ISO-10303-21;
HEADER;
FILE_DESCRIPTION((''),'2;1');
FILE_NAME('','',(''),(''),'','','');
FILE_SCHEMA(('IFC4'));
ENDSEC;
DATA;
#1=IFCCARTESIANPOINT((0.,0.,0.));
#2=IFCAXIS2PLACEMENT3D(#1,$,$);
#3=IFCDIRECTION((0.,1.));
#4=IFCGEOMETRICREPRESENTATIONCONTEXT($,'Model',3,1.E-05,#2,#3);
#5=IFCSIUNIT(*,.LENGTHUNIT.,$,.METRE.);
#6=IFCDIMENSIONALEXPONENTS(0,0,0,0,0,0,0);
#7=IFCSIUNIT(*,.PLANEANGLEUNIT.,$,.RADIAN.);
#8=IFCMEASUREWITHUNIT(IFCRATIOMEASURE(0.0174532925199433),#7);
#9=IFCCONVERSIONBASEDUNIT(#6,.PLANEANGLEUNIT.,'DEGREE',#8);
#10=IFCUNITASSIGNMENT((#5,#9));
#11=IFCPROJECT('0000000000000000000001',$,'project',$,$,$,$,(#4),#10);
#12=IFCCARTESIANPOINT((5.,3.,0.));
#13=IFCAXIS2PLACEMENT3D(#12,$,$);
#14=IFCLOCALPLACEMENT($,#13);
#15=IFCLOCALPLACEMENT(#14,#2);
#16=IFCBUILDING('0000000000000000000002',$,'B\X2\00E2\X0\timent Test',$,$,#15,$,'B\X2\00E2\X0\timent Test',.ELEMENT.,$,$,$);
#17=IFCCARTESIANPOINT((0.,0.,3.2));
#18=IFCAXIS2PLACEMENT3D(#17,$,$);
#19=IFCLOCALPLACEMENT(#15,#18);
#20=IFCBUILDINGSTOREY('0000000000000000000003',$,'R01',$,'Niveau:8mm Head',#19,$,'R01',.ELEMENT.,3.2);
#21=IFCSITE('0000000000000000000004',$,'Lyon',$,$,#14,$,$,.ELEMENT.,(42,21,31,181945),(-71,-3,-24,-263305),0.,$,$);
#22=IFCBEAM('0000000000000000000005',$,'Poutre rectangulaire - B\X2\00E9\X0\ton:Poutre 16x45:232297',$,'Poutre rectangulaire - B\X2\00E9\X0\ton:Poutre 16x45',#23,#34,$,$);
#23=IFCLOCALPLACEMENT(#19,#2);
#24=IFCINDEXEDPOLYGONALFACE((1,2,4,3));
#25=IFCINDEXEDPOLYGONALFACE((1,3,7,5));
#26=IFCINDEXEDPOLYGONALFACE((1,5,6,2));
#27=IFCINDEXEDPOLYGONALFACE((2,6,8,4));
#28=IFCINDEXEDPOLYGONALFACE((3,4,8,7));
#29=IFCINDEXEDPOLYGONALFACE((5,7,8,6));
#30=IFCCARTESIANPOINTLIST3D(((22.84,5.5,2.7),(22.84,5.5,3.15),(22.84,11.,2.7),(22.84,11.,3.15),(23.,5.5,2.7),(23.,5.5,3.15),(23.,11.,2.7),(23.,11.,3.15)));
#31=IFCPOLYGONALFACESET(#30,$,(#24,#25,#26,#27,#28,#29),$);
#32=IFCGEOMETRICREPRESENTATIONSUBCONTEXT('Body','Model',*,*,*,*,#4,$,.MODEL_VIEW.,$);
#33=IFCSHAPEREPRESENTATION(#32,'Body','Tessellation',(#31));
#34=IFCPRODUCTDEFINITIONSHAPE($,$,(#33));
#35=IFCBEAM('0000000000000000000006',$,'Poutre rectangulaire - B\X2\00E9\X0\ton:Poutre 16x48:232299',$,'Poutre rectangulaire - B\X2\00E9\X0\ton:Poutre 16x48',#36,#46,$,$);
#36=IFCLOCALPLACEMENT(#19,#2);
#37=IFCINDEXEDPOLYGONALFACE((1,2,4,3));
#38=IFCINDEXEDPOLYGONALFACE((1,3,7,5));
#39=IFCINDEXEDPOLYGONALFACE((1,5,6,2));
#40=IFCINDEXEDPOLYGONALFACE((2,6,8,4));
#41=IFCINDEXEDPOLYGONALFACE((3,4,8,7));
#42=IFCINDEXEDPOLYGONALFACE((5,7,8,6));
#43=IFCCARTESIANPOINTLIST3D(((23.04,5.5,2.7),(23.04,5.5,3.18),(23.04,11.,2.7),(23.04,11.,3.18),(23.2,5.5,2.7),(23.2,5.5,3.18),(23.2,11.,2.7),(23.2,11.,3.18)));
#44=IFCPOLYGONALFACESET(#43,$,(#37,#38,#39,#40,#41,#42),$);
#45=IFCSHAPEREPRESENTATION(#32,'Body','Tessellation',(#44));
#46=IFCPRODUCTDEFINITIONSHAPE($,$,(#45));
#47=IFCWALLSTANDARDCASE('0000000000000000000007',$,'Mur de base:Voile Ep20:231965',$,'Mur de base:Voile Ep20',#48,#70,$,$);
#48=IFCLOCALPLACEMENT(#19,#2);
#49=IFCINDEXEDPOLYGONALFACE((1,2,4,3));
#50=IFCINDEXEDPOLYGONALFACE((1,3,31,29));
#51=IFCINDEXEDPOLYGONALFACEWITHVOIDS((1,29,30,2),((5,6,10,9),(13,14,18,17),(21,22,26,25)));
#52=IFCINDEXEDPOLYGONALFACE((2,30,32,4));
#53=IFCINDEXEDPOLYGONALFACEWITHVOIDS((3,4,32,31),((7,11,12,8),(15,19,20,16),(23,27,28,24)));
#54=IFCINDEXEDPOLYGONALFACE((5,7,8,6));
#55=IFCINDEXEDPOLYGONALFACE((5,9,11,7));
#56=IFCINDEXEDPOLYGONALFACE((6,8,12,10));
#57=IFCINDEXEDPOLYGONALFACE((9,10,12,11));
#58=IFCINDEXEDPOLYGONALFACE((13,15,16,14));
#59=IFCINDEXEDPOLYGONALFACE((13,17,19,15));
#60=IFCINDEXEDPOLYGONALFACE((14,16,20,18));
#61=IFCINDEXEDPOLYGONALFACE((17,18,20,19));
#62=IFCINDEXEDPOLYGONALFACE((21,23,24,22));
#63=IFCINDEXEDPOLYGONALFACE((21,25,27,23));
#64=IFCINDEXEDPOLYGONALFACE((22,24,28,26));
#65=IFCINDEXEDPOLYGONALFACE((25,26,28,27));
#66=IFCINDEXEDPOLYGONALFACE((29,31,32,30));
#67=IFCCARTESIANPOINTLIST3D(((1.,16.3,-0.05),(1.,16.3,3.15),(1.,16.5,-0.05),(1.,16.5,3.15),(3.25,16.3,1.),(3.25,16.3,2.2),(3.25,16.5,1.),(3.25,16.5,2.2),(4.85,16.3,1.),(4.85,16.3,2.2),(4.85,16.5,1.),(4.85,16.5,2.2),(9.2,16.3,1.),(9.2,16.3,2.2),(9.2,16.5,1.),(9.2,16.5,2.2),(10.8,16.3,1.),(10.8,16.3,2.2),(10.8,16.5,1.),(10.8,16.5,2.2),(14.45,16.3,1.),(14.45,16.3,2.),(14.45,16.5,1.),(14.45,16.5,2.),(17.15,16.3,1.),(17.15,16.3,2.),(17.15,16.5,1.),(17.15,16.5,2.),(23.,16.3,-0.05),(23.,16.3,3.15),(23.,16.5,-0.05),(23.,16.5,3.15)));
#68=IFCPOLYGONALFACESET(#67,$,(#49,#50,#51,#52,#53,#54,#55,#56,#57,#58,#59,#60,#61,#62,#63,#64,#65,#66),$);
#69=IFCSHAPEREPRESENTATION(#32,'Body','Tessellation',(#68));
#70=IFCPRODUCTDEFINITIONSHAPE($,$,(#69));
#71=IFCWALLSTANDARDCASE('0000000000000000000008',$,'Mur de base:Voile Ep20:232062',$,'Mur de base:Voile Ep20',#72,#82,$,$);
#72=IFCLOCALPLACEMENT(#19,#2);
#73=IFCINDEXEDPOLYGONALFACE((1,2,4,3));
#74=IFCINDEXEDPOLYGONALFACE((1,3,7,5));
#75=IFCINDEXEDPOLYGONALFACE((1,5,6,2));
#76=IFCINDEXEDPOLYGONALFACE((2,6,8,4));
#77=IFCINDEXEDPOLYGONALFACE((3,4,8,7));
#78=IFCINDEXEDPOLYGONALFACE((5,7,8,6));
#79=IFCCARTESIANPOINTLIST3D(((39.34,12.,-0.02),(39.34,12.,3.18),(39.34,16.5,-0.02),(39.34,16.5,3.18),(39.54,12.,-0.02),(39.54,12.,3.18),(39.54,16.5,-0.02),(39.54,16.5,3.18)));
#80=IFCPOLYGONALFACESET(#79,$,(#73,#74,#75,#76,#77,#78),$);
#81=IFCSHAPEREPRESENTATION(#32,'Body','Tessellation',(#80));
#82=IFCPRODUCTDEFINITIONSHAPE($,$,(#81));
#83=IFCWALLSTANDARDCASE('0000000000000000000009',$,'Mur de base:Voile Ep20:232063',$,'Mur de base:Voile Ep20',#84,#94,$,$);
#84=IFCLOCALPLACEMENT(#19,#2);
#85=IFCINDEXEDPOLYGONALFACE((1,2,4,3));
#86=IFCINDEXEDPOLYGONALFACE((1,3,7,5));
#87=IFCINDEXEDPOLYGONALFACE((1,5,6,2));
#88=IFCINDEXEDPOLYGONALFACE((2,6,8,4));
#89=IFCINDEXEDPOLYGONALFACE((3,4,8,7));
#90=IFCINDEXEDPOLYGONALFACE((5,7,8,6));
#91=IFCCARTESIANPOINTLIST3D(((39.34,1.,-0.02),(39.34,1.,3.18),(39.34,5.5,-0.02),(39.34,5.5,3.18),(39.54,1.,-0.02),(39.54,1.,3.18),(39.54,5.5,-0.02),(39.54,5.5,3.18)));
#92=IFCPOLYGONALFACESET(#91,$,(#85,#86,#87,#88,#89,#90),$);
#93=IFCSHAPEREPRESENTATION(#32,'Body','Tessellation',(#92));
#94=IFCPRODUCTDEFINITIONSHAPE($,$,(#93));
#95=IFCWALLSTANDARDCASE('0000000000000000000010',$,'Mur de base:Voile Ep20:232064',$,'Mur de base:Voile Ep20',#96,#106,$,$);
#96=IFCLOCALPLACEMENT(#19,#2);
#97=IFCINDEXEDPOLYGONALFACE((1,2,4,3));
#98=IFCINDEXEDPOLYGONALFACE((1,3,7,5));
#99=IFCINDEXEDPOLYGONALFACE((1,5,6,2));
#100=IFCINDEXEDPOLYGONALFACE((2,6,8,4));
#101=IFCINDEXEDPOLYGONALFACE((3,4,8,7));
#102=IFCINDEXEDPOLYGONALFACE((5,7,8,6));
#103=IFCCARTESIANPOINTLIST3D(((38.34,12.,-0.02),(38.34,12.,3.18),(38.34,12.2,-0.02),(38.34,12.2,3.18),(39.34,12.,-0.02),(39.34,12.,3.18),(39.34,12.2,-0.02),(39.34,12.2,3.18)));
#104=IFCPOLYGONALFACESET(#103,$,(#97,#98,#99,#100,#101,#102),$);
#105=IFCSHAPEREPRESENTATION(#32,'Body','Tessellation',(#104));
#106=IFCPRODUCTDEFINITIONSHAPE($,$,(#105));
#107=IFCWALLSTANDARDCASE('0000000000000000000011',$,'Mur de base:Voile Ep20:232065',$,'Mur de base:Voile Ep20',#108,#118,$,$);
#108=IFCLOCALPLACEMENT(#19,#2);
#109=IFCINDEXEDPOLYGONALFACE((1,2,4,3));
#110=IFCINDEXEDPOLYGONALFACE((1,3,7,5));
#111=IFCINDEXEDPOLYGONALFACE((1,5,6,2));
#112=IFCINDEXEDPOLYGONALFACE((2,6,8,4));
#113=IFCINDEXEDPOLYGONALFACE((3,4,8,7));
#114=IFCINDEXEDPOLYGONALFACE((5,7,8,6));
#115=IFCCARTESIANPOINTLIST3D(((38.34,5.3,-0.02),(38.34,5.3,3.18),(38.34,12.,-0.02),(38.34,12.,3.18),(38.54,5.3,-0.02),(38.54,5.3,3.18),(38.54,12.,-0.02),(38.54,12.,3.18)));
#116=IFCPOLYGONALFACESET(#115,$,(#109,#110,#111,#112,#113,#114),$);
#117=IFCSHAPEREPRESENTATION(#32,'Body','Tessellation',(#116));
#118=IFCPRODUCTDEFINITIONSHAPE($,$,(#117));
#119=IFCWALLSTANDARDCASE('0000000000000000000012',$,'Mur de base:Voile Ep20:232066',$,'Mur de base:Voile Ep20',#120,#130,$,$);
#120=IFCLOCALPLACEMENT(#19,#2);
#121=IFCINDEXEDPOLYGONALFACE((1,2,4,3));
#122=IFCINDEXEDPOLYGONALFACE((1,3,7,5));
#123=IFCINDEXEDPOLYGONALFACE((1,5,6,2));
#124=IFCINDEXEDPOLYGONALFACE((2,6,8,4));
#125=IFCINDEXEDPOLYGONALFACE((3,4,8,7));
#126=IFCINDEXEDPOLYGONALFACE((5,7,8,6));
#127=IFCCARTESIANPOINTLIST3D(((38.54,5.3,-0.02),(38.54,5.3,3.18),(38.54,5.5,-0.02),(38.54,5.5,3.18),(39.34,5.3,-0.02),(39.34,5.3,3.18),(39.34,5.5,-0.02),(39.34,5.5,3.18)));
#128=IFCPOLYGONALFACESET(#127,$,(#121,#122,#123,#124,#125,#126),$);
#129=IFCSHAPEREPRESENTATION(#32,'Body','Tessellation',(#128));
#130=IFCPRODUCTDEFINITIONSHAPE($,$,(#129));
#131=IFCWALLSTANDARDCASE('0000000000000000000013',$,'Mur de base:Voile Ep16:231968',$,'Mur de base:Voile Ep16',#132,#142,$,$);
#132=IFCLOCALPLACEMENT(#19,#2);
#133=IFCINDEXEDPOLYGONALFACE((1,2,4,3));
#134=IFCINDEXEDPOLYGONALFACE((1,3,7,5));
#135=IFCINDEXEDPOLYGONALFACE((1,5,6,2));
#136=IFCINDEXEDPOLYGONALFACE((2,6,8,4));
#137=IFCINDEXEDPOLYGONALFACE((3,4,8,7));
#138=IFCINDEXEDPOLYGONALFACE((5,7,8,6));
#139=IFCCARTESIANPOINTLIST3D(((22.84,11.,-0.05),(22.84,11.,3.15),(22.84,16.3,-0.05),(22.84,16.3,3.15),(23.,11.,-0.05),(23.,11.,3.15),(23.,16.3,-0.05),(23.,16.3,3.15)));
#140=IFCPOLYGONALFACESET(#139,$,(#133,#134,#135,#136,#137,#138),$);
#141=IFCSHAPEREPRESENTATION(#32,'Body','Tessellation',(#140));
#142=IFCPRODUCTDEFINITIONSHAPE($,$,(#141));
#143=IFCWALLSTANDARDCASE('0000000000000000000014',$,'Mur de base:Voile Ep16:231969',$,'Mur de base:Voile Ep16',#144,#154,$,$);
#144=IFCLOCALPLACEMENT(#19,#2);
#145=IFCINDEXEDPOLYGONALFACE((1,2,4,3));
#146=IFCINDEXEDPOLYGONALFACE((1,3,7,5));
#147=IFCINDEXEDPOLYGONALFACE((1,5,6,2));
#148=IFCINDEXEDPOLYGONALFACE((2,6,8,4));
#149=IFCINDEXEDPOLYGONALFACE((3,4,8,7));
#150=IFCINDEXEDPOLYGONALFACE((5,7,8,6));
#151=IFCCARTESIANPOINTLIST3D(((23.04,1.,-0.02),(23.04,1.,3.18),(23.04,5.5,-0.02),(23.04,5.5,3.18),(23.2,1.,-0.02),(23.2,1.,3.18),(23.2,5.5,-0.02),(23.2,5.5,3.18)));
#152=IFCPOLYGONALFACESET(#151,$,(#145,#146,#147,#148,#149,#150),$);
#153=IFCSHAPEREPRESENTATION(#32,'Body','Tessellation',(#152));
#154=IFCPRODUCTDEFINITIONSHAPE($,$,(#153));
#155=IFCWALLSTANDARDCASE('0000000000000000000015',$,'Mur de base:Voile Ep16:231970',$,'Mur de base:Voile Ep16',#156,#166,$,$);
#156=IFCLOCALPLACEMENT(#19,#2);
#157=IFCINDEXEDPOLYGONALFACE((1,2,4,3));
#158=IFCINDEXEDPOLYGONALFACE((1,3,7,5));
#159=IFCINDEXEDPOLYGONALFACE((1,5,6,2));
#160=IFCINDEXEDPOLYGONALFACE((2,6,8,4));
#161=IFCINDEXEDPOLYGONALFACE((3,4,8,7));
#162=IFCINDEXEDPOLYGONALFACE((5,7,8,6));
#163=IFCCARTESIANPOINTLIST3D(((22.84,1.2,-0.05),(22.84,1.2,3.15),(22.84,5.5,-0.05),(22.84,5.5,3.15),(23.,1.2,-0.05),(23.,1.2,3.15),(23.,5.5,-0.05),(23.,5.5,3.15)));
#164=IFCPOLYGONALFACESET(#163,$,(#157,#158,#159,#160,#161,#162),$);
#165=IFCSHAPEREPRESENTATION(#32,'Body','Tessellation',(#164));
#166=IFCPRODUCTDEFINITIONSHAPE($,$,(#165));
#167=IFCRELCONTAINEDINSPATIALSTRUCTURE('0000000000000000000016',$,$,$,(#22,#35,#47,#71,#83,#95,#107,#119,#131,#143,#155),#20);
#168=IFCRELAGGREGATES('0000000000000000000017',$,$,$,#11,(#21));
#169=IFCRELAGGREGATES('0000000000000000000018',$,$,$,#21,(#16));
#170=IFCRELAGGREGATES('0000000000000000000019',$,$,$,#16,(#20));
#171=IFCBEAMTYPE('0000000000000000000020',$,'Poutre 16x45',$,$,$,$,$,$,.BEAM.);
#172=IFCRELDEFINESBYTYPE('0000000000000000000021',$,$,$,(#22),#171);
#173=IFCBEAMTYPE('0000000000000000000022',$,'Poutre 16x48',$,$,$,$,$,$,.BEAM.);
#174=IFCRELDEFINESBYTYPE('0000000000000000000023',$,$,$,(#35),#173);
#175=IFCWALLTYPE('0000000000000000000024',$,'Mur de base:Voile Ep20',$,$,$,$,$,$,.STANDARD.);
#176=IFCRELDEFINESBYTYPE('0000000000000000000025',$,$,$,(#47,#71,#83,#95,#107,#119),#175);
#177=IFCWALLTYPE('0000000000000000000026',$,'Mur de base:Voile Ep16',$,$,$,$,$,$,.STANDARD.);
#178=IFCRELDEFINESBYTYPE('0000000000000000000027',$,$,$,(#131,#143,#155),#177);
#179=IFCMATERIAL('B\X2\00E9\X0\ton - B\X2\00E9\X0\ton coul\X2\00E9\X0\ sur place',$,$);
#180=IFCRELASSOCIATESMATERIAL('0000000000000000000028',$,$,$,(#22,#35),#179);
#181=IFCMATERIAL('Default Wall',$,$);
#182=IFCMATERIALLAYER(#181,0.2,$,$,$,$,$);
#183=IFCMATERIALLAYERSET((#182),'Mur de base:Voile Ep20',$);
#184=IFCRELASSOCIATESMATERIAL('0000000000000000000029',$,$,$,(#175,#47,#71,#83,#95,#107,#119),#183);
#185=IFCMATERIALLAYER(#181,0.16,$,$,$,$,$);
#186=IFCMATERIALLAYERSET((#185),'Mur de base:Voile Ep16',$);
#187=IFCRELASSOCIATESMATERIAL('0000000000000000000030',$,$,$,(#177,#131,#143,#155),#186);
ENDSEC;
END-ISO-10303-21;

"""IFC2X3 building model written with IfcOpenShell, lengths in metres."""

from ifc_helpers import new_model, entity, si_unit, converted_unit, direction, frame, frame_2d, origin, origin_2d_with_axis, place, context, subcontext, project, spatial, rectangle, extrude, material, layer, layer_set, layer_usage, type_object, element, save


model = new_model("IFC2X3")

# Units and contexts
model_context = context("Model", 3, precision=1e-05, world=origin(), true_north=direction((0.0, 1.0)))
body_context = subcontext(model_context, "Body", "Model", "MODEL_VIEW")
ifc_project = project(units=[si_unit("LENGTHUNIT", "METRE"), converted_unit("PLANEANGLEUNIT", "DEGREE", entity("IfcRatioMeasure", 0.0174532925199433), si_unit("PLANEANGLEUNIT", "RADIAN"), dimensions=[0, 0, 0, 0, 0, 0, 0])], contexts=[model_context])

# Site, building, storey
site_placement = place(None, frame((5.0, 3.0, 0.0)))
site = spatial("IfcSite", under=ifc_project, at=site_placement, Name="Lyon", CompositionType="ELEMENT", RefLatitude=(42, 21, 31, 181945), RefLongitude=(-71, -3, -24, -263305), RefElevation=0.0)
building_placement = place(site_placement, origin())
building = spatial("IfcBuilding", under=site, at=building_placement, Name="Bâtiment Test", LongName="Bâtiment Test", CompositionType="ELEMENT")
storey_placement = place(building_placement, frame((0.0, 0.0, 3.2)))
storey = spatial("IfcBuildingStorey", under=building, at=storey_placement, Name="R01", ObjectType="Niveau:8mm Head", LongName="R01", CompositionType="ELEMENT", Elevation=3.2)

# Beams
ifc_material_1 = material(Name="Béton - Béton coulé sur place")
beam_type_1 = type_object("IfcBeamType", Name="Poutre 16x45", PredefinedType="BEAM")
beam_1_placement = place(storey_placement, frame((22.92, 5.5, 3.15), z_axis=(0.0, 0.0, 1.0), x_axis=(0.0, 1.0, 0.0)))
element("IfcBeam", 1, at=beam_1_placement, inside=storey, type_object=beam_type_1, material=ifc_material_1, Name="Poutre rectangulaire - Béton:Poutre 16x45:232297", ObjectType="Poutre rectangulaire - Béton:Poutre 16x45", context=body_context, shape_type="SweptSolid", body=[
    extrude(rectangle(XDim=0.45, YDim=0.16, at=frame_2d((0.0, 0.0), x_axis=(1.0, 0.0))), frame((0.0, 0.0, -0.225), z_axis=(1.0, 0.0, 0.0), x_axis=(0.0, 0.0, -1.0)), (0.0, 0.0, 1.0), 5.5),
])
beam_type_2 = type_object("IfcBeamType", Name="Poutre 16x48", PredefinedType="BEAM")
beam_2_placement = place(storey_placement, frame((23.12, 11.0, 3.18), z_axis=(0.0, 0.0, 1.0), x_axis=(0.0, -1.0, 0.0)))
element("IfcBeam", 2, at=beam_2_placement, inside=storey, type_object=beam_type_2, material=ifc_material_1, Name="Poutre rectangulaire - Béton:Poutre 16x48:232299", ObjectType="Poutre rectangulaire - Béton:Poutre 16x48", context=body_context, shape_type="SweptSolid", body=[
    extrude(rectangle(XDim=0.48, YDim=0.16, at=frame_2d((0.0, 0.0), x_axis=(1.0, 0.0))), frame((0.0, 0.0, -0.24), z_axis=(1.0, 0.0, 0.0), x_axis=(0.0, 0.0, -1.0)), (0.0, 0.0, 1.0), 5.5),
])

# Wall, openings
ifc_material_2 = material(Name="Default Wall")
ifc_layer_1 = layer(ifc_material_2, 0.2)
ifc_layer_set_1 = layer_set([ifc_layer_1], Name="Mur de base:Voile Ep20")
ifc_layer_usage_1 = layer_usage(ifc_layer_set_1, "AXIS2", "POSITIVE", -0.1)
wall_type_1 = type_object("IfcWallType", Name="Mur de base:Voile Ep20", PredefinedType="STANDARD", material=ifc_layer_set_1)
wall_1_placement = place(storey_placement, frame((23.0, 16.4, -0.05), z_axis=(0.0, 0.0, 1.0), x_axis=(-1.0, 0.0, 0.0)))
wall_1 = element("IfcWallStandardCase", 3, at=wall_1_placement, inside=storey, type_object=wall_type_1, material=ifc_layer_usage_1, Name="Mur de base:Voile Ep20:231965", ObjectType="Mur de base:Voile Ep20", context=body_context, shape_type="SweptSolid", body=[
    extrude(rectangle(XDim=22.0, YDim=0.2, at=frame_2d((11.0, 0.0), x_axis=(-1.0, 0.0))), origin(), (0.0, 0.0, 1.0), 3.2),
])
opening_1_placement = place(wall_1_placement, origin())
element("IfcOpeningElement", 4, at=opening_1_placement, cuts=wall_1, ObjectType="Opening", context=body_context, shape_type="SweptSolid", body=[
    extrude(rectangle(XDim=1.0, YDim=2.7, at=frame_2d((0.0, 0.0), x_axis=(1.0, 0.0))), frame((7.2, -0.1, 1.55), z_axis=(0.0, 1.0, 0.0), x_axis=(0.0, 0.0, -1.0)), (0.0, 0.0, 1.0), 0.2),
])
opening_2_placement = place(wall_1_placement, origin())
element("IfcOpeningElement", 5, at=opening_2_placement, cuts=wall_1, ObjectType="Opening", context=body_context, shape_type="SweptSolid", body=[
    extrude(rectangle(XDim=1.2, YDim=1.6, at=origin_2d_with_axis()), frame((13.0, -0.1, 1.65), z_axis=(0.0, 1.0, 0.0), x_axis=(0.0, 0.0, -1.0)), (0.0, 0.0, 1.0), 0.2),
])
opening_3_placement = place(wall_1_placement, origin())
element("IfcOpeningElement", 6, at=opening_3_placement, cuts=wall_1, ObjectType="Opening", context=body_context, shape_type="SweptSolid", body=[
    extrude(rectangle(XDim=1.2, YDim=1.6, at=frame_2d((0.0, 0.0), x_axis=(1.0, 0.0))), frame((18.95, -0.1, 1.65), z_axis=(0.0, 1.0, 0.0), x_axis=(0.0, 0.0, -1.0)), (0.0, 0.0, 1.0), 0.2),
])

# Walls
ifc_layer_usage_2 = layer_usage(ifc_layer_set_1, "AXIS2", "NEGATIVE", 0.1)
wall_2_placement = place(storey_placement, frame((39.44, 16.5, -0.02), z_axis=(0.0, 0.0, 1.0), x_axis=(0.0, -1.0, 0.0)))
element("IfcWallStandardCase", 7, at=wall_2_placement, inside=storey, type_object=wall_type_1, material=ifc_layer_usage_2, Name="Mur de base:Voile Ep20:232062", ObjectType="Mur de base:Voile Ep20", context=body_context, shape_type="SweptSolid", body=[
    extrude(rectangle(XDim=4.5, YDim=0.2, at=frame_2d((2.25, 0.0), x_axis=(-1.0, 0.0))), origin(), (0.0, 0.0, 1.0), 3.2),
])
ifc_layer_usage_3 = layer_usage(ifc_layer_set_1, "AXIS2", "NEGATIVE", 0.1)
wall_3_placement = place(storey_placement, frame((39.44, 5.5, -0.02), z_axis=(0.0, 0.0, 1.0), x_axis=(0.0, -1.0, 0.0)))
element("IfcWallStandardCase", 8, at=wall_3_placement, inside=storey, type_object=wall_type_1, material=ifc_layer_usage_3, Name="Mur de base:Voile Ep20:232063", ObjectType="Mur de base:Voile Ep20", context=body_context, shape_type="SweptSolid", body=[
    extrude(rectangle(XDim=4.5, YDim=0.2, at=frame_2d((2.25, 0.0), x_axis=(-1.0, 0.0))), origin(), (0.0, 0.0, 1.0), 3.2),
])
ifc_layer_usage_4 = layer_usage(ifc_layer_set_1, "AXIS2", "NEGATIVE", 0.1)
wall_4_placement = place(storey_placement, frame((39.34, 12.1, -0.02), z_axis=(0.0, 0.0, 1.0), x_axis=(-1.0, 0.0, 0.0)))
element("IfcWallStandardCase", 9, at=wall_4_placement, inside=storey, type_object=wall_type_1, material=ifc_layer_usage_4, Name="Mur de base:Voile Ep20:232064", ObjectType="Mur de base:Voile Ep20", context=body_context, shape_type="SweptSolid", body=[
    extrude(rectangle(XDim=1.0, YDim=0.2, at=frame_2d((0.5, 0.0), x_axis=(-1.0, 0.0))), origin(), (0.0, 0.0, 1.0), 3.2),
])
ifc_layer_usage_5 = layer_usage(ifc_layer_set_1, "AXIS2", "NEGATIVE", 0.1)
wall_5_placement = place(storey_placement, frame((38.44, 12.0, -0.02), z_axis=(0.0, 0.0, 1.0), x_axis=(0.0, -1.0, 0.0)))
element("IfcWallStandardCase", 10, at=wall_5_placement, inside=storey, type_object=wall_type_1, material=ifc_layer_usage_5, Name="Mur de base:Voile Ep20:232065", ObjectType="Mur de base:Voile Ep20", context=body_context, shape_type="SweptSolid", body=[
    extrude(rectangle(XDim=6.7, YDim=0.2, at=frame_2d((3.35, 0.0), x_axis=(-1.0, 0.0))), origin(), (0.0, 0.0, 1.0), 3.2),
])
ifc_layer_usage_6 = layer_usage(ifc_layer_set_1, "AXIS2", "NEGATIVE", 0.1)
wall_6_placement = place(storey_placement, frame((38.54, 5.4, -0.02)))
element("IfcWallStandardCase", 11, at=wall_6_placement, inside=storey, type_object=wall_type_1, material=ifc_layer_usage_6, Name="Mur de base:Voile Ep20:232066", ObjectType="Mur de base:Voile Ep20", context=body_context, shape_type="SweptSolid", body=[
    extrude(rectangle(XDim=0.8, YDim=0.2, at=frame_2d((0.4, 0.0), x_axis=(-1.0, 0.0))), origin(), (0.0, 0.0, 1.0), 3.2),
])
ifc_layer_2 = layer(ifc_material_2, 0.16)
ifc_layer_set_2 = layer_set([ifc_layer_2], Name="Mur de base:Voile Ep16")
ifc_layer_usage_7 = layer_usage(ifc_layer_set_2, "AXIS2", "NEGATIVE", 0.08)
wall_type_2 = type_object("IfcWallType", Name="Mur de base:Voile Ep16", PredefinedType="STANDARD", material=ifc_layer_set_2)
wall_7_placement = place(storey_placement, frame((22.92, 16.3, -0.05), z_axis=(0.0, 0.0, 1.0), x_axis=(0.0, -1.0, 0.0)))
element("IfcWallStandardCase", 12, at=wall_7_placement, inside=storey, type_object=wall_type_2, material=ifc_layer_usage_7, Name="Mur de base:Voile Ep16:231968", ObjectType="Mur de base:Voile Ep16", context=body_context, shape_type="SweptSolid", body=[
    extrude(rectangle(XDim=5.3, YDim=0.16, at=frame_2d((2.65, 0.0), x_axis=(-1.0, 0.0))), origin(), (0.0, 0.0, 1.0), 3.2),
])
ifc_layer_usage_8 = layer_usage(ifc_layer_set_2, "AXIS2", "NEGATIVE", 0.08)
wall_8_placement = place(storey_placement, frame((23.12, 1.0, -0.02), z_axis=(0.0, 0.0, 1.0), x_axis=(0.0, 1.0, 0.0)))
element("IfcWallStandardCase", 13, at=wall_8_placement, inside=storey, type_object=wall_type_2, material=ifc_layer_usage_8, Name="Mur de base:Voile Ep16:231969", ObjectType="Mur de base:Voile Ep16", context=body_context, shape_type="SweptSolid", body=[
    extrude(rectangle(XDim=4.5, YDim=0.16, at=frame_2d((2.25, 0.0), x_axis=(-1.0, 0.0))), origin(), (0.0, 0.0, 1.0), 3.2),
])
ifc_layer_usage_9 = layer_usage(ifc_layer_set_2, "AXIS2", "NEGATIVE", 0.08)
wall_9_placement = place(storey_placement, frame((22.92, 5.5, -0.05), z_axis=(0.0, 0.0, 1.0), x_axis=(0.0, -1.0, 0.0)))
element("IfcWallStandardCase", 14, at=wall_9_placement, inside=storey, type_object=wall_type_2, material=ifc_layer_usage_9, Name="Mur de base:Voile Ep16:231970", ObjectType="Mur de base:Voile Ep16", context=body_context, shape_type="SweptSolid", body=[
    extrude(rectangle(XDim=4.3, YDim=0.16, at=frame_2d((2.15, 0.0), x_axis=(-1.0, 0.0))), origin(), (0.0, 0.0, 1.0), 3.2),
])

save(model, "model.ifc")
